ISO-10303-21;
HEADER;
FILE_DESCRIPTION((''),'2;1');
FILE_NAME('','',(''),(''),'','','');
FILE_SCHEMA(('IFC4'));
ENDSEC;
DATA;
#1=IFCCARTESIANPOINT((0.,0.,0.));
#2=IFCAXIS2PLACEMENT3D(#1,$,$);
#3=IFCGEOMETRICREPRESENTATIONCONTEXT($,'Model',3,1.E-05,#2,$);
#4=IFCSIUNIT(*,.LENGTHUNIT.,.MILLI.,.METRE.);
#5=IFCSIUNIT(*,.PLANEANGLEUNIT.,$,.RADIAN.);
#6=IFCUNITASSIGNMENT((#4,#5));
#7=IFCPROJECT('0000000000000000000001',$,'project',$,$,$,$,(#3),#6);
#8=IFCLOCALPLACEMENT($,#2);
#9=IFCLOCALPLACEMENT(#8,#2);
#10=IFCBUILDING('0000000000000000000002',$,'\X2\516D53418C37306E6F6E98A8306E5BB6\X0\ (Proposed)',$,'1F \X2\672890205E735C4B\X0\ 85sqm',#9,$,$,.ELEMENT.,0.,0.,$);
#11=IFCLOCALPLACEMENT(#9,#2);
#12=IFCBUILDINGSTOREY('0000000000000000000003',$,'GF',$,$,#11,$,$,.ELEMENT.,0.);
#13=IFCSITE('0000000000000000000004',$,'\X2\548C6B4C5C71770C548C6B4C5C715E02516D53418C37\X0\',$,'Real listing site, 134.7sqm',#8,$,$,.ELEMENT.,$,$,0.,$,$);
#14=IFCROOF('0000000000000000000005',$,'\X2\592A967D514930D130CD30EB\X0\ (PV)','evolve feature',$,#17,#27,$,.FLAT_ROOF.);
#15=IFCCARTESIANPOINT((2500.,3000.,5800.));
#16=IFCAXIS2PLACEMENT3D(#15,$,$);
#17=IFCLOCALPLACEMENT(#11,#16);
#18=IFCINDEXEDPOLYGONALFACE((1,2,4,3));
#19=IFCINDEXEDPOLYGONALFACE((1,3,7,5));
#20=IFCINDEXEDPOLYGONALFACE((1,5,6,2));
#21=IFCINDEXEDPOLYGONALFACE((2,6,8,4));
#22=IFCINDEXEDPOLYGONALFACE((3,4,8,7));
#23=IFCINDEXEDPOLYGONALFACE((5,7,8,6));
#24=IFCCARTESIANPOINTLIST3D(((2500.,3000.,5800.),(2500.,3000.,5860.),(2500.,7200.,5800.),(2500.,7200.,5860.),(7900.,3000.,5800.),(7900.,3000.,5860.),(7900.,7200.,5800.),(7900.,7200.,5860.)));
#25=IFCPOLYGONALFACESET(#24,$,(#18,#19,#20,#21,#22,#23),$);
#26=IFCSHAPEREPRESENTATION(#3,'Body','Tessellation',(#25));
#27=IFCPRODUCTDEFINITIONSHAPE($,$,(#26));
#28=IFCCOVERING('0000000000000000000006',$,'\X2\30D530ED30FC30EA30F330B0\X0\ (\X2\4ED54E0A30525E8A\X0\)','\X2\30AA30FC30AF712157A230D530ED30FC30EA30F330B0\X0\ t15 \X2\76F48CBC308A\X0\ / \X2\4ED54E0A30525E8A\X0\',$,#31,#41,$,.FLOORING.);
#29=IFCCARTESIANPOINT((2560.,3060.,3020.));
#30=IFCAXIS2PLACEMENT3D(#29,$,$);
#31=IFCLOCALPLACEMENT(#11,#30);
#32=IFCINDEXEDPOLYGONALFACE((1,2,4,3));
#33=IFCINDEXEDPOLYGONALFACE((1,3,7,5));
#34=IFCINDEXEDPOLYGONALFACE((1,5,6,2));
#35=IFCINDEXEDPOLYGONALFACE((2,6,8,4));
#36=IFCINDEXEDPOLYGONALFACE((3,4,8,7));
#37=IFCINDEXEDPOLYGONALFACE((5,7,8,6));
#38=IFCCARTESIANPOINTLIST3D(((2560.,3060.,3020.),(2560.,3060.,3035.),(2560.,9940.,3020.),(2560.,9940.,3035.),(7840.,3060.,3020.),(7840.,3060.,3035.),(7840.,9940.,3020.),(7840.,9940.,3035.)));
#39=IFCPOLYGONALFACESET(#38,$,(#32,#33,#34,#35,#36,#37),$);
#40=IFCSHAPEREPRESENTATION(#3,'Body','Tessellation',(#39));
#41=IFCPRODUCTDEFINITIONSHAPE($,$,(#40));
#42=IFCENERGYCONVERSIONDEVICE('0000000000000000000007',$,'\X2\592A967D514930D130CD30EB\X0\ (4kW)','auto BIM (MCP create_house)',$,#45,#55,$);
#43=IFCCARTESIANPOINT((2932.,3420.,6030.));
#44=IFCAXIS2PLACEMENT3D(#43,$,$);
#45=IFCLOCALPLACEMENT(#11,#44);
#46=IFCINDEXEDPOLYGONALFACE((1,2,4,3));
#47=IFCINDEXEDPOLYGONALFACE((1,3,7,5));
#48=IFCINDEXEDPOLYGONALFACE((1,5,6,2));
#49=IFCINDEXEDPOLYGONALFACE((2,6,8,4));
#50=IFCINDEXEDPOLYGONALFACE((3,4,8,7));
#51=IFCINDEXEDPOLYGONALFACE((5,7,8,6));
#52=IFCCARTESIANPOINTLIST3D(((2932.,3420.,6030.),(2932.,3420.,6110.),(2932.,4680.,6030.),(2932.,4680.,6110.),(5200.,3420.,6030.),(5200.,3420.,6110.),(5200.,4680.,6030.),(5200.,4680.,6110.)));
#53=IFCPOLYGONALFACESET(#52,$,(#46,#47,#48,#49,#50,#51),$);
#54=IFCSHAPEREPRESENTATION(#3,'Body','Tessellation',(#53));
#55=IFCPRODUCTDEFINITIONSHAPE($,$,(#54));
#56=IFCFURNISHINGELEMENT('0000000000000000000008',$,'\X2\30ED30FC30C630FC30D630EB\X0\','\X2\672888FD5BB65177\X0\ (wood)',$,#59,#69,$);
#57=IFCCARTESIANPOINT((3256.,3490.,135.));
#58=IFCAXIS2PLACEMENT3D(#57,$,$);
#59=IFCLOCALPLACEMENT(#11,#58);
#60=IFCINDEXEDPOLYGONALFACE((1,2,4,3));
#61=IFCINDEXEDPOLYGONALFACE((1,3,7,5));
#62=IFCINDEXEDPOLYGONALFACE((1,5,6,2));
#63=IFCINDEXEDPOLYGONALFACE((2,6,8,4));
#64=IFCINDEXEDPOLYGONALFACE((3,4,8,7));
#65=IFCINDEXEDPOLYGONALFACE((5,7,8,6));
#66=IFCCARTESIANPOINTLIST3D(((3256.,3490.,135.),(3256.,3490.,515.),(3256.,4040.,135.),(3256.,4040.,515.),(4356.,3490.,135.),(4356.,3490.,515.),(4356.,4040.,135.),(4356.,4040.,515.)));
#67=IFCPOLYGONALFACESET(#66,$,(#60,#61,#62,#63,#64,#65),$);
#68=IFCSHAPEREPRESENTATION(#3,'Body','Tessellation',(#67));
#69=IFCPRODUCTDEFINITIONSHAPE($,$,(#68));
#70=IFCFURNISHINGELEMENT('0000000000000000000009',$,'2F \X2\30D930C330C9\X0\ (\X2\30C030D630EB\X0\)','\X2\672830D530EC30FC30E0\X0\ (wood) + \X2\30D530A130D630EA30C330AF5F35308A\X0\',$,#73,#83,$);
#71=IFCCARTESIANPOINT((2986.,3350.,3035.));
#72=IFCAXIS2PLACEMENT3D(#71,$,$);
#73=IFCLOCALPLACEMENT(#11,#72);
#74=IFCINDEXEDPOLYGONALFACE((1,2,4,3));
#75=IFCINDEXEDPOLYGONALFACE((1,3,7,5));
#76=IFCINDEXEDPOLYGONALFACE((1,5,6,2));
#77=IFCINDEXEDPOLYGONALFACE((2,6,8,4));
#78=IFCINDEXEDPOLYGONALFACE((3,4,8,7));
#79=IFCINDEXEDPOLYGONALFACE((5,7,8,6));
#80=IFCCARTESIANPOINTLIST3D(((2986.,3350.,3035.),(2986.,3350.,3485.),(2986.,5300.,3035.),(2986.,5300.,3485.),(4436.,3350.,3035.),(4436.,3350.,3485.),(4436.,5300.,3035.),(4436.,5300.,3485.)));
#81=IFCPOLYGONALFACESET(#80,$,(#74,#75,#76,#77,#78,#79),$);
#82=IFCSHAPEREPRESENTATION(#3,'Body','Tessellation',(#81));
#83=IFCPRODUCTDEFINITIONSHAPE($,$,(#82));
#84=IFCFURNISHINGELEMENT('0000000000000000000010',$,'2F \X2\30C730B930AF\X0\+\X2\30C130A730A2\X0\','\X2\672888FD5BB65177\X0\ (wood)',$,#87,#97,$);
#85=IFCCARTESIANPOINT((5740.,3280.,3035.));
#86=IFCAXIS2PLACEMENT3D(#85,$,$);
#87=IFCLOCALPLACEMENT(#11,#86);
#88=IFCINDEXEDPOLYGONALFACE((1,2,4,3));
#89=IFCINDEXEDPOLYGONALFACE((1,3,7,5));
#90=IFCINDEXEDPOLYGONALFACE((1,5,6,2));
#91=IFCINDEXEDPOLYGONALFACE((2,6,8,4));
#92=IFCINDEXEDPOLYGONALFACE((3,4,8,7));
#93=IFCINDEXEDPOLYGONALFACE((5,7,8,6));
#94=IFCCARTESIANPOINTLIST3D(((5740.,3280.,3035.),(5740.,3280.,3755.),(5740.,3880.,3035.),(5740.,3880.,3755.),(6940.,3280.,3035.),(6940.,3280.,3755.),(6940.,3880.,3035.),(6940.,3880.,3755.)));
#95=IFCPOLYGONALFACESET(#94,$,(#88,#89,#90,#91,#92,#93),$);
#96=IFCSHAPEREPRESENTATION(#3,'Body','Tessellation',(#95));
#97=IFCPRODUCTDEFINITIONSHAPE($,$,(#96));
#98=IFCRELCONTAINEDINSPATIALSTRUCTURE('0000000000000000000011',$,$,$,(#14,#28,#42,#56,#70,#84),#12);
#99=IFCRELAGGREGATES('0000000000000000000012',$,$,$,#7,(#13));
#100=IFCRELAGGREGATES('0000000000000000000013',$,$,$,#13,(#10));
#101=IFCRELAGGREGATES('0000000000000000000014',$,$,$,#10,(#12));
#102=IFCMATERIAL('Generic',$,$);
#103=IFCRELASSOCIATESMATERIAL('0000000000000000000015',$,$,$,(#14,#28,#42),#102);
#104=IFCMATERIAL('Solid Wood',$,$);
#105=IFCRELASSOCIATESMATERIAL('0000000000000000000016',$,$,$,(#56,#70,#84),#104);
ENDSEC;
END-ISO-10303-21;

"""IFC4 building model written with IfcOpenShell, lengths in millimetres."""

from ifc_helpers import new_model, si_unit, frame, frame_2d, origin, place, context, project, spatial, rectangle, extrude, material, element, save


model = new_model("IFC4")

# Units and contexts
model_context = context("Model", 3, precision=1e-05, world=origin())
ifc_project = project(units=[si_unit("LENGTHUNIT", "METRE", prefix="MILLI"), si_unit("PLANEANGLEUNIT", "RADIAN")], contexts=[model_context])

# Site, building, storey
site_placement = place(None, origin())
site = spatial("IfcSite", under=ifc_project, at=site_placement, Name="和歌山県和歌山市六十谷", ObjectType="Real listing site, 134.7sqm", CompositionType="ELEMENT", RefElevation=0.0)
building_placement = place(site_placement, origin())
building = spatial("IfcBuilding", under=site, at=building_placement, Name="六十谷の潮風の家 (Proposed)", ObjectType="1F 木造平屋 85sqm", CompositionType="ELEMENT", ElevationOfRefHeight=0.0, ElevationOfTerrain=0.0)
storey_placement = place(building_placement, origin())
storey = spatial("IfcBuildingStorey", under=building, at=storey_placement, Name="GF", CompositionType="ELEMENT", Elevation=0.0)

# Shared definitions
ifc_material_1 = material(Name="Solid Wood")

# Shared definitions
ifc_material_2 = material(Name="Generic")

# Roof
roof_1_placement = place(storey_placement, frame((2500.0, 3000.0, 5800.0)))
element("IfcRoof", 1, at=roof_1_placement, inside=storey, material=ifc_material_2, Name="太陽光パネル (PV)", Description="evolve feature", PredefinedType="FLAT_ROOF", context=model_context, shape_type="SweptSolid", body=[
    extrude(rectangle(XDim=5400.0, YDim=4200.0, at=frame_2d((2700.0, 2100.0))), frame((2500.0, 3000.0, 5800.0)), (0.0, 0.0, 1.0), 60.0),
])

# Covering
covering_placement = place(storey_placement, frame((2560.0, 3060.0, 3020.0)))
element("IfcCovering", 2, at=covering_placement, inside=storey, material=ifc_material_2, Name="フローリング (仕上げ床)", Description="オーク無垢フローリング t15 直貼り / 仕上げ床", PredefinedType="FLOORING", context=model_context, shape_type="SweptSolid", body=[
    extrude(rectangle(XDim=5280.0, YDim=6880.0, at=frame_2d((2640.0, 3440.0))), frame((2560.0, 3060.0, 3020.0)), (0.0, 0.0, 1.0), 15.0),
])

# Energy conversion device
energy_conversion_device_placement = place(storey_placement, frame((2932.0, 3420.0, 6030.0)))
element("IfcEnergyConversionDevice", 3, at=energy_conversion_device_placement, inside=storey, material=ifc_material_2, Name="太陽光パネル (4kW)", Description="auto BIM (MCP create_house)", context=model_context, shape_type="SweptSolid", body=[
    extrude(rectangle(XDim=2268.0, YDim=1260.0, at=frame_2d((1134.0, 630.0))), frame((2932.0, 3420.0, 6030.0)), (0.0, 0.0, 1.0), 80.0),
])

# Furnishing elements
furnishing_1_placement = place(storey_placement, frame((3256.0, 3490.0, 135.0)))
element("IfcFurnishingElement", 4, at=furnishing_1_placement, inside=storey, material=ifc_material_1, Name="ローテーブル", Description="木製家具 (wood)", context=model_context, shape_type="SweptSolid", body=[
    extrude(rectangle(XDim=1100.0, YDim=550.0, at=frame_2d((550.0, 275.0))), frame((3256.0, 3490.0, 135.0)), (0.0, 0.0, 1.0), 380.0),
])
furnishing_2_placement = place(storey_placement, frame((2986.0, 3350.0, 3035.0)))
element("IfcFurnishingElement", 5, at=furnishing_2_placement, inside=storey, material=ifc_material_1, Name="2F ベッド (ダブル)", Description="木フレーム (wood) + ファブリック張り", context=model_context, shape_type="SweptSolid", body=[
    extrude(rectangle(XDim=1450.0, YDim=1950.0, at=frame_2d((725.0, 975.0))), frame((2986.0, 3350.0, 3035.0)), (0.0, 0.0, 1.0), 450.0),
])
furnishing_3_placement = place(storey_placement, frame((5740.0, 3280.0, 3035.0)))
element("IfcFurnishingElement", 6, at=furnishing_3_placement, inside=storey, material=ifc_material_1, Name="2F デスク+チェア", Description="木製家具 (wood)", context=model_context, shape_type="SweptSolid", body=[
    extrude(rectangle(XDim=1200.0, YDim=600.0, at=frame_2d((600.0, 300.0))), frame((5740.0, 3280.0, 3035.0)), (0.0, 0.0, 1.0), 720.0),
])

save(model, "model.ifc")
